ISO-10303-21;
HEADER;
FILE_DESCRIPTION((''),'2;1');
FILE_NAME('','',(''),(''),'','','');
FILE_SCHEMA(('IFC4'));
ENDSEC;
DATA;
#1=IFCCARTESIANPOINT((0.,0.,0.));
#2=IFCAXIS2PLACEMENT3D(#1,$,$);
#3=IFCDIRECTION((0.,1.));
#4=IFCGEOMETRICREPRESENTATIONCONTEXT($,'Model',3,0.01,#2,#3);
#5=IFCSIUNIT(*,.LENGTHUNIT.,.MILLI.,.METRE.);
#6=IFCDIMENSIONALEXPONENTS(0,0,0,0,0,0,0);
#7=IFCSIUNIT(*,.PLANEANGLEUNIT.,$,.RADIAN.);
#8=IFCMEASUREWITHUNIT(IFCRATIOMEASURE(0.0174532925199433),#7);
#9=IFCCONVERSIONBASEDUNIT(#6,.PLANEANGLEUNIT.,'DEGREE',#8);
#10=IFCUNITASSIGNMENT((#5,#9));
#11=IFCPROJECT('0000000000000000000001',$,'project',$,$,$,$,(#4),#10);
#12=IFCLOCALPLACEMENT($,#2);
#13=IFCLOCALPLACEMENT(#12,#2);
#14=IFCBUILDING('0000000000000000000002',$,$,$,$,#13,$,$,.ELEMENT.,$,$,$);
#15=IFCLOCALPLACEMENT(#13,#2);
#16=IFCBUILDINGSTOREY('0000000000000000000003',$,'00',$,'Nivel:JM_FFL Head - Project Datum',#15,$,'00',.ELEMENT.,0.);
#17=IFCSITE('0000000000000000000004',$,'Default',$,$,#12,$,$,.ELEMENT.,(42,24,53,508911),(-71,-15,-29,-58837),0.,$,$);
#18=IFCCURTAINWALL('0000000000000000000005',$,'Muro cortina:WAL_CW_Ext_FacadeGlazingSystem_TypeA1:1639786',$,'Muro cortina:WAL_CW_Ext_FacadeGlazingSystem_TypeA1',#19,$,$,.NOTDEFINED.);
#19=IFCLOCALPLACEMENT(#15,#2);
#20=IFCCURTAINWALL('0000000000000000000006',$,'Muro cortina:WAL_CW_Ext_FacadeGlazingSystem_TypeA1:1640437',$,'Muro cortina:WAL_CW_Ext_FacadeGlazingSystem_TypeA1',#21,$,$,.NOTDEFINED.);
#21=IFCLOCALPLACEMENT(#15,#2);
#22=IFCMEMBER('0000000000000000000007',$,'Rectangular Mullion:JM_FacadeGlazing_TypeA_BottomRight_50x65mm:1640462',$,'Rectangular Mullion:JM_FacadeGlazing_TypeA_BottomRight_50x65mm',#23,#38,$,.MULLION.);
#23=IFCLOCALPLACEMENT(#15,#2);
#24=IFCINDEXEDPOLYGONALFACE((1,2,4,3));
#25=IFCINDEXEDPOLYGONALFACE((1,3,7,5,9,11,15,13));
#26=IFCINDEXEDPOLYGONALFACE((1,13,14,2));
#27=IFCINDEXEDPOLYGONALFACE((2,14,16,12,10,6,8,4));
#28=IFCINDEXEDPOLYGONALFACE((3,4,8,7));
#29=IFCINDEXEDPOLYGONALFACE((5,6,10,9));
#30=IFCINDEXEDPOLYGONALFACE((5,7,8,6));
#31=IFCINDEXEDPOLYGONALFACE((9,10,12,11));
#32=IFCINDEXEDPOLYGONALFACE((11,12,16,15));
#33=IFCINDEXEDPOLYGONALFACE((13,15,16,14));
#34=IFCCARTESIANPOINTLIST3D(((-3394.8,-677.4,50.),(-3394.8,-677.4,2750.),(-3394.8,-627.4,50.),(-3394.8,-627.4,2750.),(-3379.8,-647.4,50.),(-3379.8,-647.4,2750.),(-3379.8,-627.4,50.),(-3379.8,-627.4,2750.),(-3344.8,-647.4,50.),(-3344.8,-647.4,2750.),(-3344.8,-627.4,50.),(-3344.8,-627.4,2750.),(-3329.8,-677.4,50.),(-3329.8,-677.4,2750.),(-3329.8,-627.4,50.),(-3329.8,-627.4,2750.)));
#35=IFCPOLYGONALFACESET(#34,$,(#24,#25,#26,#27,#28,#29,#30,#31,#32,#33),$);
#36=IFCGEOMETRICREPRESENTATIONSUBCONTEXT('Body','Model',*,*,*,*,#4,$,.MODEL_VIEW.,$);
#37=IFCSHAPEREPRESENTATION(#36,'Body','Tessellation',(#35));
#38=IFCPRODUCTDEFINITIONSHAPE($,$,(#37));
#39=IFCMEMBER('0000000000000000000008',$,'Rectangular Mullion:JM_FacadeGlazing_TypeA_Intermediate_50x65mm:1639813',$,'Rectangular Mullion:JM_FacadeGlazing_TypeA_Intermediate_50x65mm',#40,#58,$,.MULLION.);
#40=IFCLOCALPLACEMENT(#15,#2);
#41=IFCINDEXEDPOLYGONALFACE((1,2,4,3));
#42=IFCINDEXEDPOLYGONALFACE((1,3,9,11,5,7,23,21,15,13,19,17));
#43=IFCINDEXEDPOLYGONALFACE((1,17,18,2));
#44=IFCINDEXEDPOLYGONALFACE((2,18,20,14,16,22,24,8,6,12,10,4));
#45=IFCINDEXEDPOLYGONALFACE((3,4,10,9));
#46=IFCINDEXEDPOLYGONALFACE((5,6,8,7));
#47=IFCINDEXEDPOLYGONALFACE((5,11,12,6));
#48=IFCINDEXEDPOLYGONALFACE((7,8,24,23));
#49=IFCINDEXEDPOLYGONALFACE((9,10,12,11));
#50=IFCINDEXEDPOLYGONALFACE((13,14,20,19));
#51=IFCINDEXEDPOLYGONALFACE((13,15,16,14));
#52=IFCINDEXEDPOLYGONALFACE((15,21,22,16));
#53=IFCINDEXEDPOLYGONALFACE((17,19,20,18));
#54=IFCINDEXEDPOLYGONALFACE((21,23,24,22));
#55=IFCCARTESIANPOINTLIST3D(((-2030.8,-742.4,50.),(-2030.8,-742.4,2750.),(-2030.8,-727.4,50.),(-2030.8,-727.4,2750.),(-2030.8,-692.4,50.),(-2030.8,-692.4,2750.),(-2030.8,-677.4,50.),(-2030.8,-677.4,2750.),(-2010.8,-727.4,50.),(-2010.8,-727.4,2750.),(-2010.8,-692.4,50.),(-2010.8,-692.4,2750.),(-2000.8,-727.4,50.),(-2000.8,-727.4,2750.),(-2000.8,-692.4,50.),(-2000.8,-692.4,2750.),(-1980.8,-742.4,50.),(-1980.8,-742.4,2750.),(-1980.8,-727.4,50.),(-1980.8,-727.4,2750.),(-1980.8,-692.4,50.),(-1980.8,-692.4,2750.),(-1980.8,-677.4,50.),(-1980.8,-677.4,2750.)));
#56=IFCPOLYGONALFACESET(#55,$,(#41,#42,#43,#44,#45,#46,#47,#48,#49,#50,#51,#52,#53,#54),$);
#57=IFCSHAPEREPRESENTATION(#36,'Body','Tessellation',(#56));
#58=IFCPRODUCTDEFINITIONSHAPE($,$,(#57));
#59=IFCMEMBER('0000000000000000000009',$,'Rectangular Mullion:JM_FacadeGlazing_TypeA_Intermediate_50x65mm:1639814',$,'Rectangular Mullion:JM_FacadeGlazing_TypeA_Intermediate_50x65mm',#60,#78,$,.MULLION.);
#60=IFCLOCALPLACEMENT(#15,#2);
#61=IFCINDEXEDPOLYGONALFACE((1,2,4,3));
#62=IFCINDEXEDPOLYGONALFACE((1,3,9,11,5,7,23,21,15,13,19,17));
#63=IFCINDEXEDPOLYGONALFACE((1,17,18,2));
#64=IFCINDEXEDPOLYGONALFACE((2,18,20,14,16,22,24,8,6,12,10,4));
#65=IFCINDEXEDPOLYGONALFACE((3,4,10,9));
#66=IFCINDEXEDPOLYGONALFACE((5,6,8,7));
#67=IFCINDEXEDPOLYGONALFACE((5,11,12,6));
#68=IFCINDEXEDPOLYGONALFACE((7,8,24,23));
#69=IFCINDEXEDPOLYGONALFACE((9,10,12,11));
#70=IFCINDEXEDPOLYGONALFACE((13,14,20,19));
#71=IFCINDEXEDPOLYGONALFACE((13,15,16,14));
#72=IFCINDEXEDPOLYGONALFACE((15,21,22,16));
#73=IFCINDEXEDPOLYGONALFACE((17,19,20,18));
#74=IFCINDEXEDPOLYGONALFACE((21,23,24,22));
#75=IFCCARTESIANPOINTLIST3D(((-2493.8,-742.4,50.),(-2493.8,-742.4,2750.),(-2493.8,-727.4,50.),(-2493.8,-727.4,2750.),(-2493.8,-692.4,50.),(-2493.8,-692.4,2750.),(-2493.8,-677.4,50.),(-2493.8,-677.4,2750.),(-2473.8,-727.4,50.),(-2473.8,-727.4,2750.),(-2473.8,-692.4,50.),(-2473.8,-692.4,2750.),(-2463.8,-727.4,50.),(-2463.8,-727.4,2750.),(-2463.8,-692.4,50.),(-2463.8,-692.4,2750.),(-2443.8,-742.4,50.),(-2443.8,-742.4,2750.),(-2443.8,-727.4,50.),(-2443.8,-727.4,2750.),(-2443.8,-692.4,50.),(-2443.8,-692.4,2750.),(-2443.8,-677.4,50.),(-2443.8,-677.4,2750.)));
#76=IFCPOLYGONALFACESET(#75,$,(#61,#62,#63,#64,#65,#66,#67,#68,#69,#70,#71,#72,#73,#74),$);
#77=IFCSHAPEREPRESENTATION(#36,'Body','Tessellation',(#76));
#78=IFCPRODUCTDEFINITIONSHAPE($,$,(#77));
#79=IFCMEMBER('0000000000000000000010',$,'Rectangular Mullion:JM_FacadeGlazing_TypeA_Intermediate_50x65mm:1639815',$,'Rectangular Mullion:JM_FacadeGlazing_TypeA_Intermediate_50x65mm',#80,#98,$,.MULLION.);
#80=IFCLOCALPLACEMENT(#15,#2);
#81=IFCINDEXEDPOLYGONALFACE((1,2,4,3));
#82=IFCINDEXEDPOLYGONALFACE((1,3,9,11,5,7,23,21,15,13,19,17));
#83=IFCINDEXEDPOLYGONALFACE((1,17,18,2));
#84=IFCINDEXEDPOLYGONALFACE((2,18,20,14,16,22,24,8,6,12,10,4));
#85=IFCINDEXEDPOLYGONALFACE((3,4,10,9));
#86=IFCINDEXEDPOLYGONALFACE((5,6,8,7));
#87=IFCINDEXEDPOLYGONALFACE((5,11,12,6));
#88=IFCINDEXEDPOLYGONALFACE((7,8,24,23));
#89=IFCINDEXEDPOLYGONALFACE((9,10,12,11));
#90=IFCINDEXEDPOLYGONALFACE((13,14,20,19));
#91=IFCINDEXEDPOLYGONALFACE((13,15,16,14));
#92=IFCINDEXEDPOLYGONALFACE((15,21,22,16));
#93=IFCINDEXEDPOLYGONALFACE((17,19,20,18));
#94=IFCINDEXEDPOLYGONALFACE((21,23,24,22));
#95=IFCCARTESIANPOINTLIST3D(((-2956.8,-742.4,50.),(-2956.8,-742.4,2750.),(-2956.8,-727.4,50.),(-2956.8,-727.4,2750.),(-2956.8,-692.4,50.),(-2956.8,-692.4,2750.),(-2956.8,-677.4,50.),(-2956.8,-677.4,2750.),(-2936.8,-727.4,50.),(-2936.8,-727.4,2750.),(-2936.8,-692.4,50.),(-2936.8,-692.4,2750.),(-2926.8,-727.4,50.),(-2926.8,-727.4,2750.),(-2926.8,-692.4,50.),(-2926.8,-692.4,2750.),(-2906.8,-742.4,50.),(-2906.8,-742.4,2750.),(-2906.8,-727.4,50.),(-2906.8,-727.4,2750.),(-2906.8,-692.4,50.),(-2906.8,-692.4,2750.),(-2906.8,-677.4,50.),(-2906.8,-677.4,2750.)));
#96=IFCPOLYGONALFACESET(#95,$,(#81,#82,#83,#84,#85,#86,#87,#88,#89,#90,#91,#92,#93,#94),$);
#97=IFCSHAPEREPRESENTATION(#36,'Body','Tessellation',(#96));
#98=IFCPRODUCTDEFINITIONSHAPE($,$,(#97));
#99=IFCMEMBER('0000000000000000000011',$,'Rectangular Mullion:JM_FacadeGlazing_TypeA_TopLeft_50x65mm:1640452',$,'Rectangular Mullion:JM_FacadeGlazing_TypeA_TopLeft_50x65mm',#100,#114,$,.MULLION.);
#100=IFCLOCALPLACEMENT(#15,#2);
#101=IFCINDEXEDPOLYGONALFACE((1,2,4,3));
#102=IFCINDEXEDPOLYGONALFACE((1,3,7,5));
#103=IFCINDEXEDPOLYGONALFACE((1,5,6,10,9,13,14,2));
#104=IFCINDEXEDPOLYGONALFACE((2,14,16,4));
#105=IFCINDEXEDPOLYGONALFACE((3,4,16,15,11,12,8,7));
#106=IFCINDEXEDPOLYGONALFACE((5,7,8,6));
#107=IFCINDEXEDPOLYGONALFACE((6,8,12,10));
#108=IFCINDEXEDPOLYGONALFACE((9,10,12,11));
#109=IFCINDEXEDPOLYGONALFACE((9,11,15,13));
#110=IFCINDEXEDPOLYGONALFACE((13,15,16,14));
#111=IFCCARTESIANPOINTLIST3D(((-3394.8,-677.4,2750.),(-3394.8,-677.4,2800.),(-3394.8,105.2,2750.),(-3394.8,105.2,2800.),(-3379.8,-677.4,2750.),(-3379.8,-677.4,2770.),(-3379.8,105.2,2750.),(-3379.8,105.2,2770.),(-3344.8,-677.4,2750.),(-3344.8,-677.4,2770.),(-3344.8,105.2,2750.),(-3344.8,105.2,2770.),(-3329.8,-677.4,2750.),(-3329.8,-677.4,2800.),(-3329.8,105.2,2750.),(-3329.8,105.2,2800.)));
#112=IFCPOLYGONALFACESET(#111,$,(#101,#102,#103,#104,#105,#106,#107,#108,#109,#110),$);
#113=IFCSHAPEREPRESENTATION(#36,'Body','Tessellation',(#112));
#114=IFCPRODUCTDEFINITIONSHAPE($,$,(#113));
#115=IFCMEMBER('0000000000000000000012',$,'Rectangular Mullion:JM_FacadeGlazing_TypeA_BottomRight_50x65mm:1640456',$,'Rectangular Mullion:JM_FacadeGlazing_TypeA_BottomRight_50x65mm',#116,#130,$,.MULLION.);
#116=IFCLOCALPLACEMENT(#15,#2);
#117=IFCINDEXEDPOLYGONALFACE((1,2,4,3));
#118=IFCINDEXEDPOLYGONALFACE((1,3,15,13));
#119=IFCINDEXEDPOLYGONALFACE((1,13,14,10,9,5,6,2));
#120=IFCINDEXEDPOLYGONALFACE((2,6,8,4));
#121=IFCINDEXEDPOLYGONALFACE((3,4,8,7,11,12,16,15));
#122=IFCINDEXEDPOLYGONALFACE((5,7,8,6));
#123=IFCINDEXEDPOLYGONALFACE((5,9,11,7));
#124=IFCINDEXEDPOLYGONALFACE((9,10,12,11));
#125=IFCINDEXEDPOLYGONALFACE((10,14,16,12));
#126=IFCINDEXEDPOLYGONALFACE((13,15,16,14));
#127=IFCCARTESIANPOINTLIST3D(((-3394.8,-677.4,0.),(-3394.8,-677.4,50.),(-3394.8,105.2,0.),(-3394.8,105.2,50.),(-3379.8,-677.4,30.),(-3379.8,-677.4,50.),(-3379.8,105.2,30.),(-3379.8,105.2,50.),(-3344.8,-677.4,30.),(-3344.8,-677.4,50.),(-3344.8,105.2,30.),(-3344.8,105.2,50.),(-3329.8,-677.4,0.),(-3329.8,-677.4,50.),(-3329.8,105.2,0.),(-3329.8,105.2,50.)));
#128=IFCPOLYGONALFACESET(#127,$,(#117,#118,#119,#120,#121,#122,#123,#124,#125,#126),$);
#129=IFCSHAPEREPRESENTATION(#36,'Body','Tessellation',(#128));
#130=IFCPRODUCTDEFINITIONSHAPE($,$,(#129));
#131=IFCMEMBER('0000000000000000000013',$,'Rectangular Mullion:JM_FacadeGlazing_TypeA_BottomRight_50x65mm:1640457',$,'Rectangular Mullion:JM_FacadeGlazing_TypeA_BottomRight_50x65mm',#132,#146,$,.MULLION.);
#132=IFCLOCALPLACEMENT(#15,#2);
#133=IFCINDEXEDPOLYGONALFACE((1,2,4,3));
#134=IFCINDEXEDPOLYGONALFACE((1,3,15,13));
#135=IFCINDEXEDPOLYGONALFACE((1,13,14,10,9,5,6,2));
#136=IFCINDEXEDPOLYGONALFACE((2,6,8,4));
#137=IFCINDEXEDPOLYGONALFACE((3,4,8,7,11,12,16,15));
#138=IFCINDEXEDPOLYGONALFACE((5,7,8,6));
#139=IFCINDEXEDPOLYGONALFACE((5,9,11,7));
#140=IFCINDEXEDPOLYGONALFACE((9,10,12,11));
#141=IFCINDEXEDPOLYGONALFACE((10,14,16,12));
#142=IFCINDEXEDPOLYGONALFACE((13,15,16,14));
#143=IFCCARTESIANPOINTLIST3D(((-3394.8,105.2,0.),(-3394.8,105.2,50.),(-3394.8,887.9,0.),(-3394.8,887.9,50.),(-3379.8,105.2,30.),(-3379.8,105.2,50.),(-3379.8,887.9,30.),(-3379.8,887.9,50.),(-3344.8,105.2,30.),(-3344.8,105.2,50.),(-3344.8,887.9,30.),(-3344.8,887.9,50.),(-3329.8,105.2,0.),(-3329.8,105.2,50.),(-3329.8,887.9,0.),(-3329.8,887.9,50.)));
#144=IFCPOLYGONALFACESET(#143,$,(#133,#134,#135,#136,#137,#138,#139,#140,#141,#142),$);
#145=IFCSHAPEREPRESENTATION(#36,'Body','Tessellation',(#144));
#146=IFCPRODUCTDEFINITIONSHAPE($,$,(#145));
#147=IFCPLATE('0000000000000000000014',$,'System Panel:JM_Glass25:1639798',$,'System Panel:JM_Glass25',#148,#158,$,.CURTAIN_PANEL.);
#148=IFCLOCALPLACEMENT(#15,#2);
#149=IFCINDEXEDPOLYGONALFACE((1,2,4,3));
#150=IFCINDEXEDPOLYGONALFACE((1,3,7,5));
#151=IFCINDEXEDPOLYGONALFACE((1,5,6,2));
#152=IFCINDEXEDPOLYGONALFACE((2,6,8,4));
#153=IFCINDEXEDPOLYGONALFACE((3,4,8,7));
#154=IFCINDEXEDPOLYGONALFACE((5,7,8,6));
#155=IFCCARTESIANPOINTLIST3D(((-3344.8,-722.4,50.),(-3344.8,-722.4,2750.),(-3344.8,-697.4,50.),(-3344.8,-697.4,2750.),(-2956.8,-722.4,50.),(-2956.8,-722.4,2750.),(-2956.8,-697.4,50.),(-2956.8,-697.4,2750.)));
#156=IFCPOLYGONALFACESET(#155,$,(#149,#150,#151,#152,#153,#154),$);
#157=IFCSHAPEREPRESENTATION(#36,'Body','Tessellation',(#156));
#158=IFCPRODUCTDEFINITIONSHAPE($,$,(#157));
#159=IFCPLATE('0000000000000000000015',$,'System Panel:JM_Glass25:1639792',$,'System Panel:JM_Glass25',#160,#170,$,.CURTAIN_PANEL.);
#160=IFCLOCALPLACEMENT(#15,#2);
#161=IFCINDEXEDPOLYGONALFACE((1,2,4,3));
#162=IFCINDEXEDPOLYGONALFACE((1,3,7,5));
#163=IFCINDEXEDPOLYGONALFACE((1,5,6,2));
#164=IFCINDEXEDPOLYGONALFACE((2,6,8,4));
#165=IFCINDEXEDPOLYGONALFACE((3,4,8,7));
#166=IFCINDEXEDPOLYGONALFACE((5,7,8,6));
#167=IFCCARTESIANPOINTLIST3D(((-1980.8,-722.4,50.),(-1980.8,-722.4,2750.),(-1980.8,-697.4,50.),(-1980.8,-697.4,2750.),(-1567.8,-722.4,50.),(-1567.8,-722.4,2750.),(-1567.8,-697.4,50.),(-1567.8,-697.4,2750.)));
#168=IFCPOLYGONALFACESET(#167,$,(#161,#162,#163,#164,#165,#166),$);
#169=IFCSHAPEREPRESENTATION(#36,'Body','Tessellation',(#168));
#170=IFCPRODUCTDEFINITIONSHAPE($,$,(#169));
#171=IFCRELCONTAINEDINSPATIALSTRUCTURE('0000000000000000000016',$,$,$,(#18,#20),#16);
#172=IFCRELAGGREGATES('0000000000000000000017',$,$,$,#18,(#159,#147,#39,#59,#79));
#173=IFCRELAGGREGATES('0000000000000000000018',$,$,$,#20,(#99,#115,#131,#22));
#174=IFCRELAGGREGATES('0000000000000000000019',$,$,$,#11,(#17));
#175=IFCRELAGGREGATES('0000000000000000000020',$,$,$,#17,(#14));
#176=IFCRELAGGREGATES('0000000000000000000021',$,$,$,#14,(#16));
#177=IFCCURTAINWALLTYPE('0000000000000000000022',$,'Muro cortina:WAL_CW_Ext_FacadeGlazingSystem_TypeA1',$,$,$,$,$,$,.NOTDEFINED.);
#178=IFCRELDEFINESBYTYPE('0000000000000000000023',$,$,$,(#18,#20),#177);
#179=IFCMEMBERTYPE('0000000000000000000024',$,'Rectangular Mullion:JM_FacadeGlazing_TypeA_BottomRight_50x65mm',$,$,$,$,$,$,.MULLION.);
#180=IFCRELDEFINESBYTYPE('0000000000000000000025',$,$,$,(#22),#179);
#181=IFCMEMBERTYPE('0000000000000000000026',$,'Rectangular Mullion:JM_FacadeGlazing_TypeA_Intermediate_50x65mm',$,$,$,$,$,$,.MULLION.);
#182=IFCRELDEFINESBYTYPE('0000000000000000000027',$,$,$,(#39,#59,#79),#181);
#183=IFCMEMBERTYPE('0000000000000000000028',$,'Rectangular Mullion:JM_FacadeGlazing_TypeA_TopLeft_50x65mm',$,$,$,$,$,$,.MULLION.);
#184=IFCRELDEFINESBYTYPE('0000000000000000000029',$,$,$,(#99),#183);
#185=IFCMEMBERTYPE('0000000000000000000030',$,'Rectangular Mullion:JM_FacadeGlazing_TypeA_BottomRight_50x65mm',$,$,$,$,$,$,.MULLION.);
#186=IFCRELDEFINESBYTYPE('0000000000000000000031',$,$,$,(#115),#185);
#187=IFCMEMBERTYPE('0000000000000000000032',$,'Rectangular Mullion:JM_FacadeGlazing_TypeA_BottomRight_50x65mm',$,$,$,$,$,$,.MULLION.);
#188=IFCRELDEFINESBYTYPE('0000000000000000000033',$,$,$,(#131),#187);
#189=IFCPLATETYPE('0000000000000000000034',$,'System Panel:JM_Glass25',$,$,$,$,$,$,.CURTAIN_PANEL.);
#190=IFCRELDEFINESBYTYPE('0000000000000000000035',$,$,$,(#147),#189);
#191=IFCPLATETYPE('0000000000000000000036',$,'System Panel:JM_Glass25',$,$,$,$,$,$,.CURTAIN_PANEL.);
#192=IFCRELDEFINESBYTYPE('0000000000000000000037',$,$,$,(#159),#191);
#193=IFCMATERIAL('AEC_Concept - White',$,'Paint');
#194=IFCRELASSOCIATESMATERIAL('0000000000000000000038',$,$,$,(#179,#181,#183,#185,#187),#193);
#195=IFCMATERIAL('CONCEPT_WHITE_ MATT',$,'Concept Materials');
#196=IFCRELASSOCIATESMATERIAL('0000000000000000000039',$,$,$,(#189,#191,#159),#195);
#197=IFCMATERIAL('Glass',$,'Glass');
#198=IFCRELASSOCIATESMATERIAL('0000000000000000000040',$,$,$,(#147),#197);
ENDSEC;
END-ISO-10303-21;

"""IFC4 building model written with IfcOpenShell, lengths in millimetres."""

from ifc_helpers import new_model, entity, si_unit, converted_unit, direction, frame, origin, place, context, subcontext, project, spatial, indexed_curve, outline, extrude, source, transform, mapped, material, type_object, type_shapes, element, aggregate, save


model = new_model("IFC4")

# Units and contexts
model_context = context("Model", 3, precision=0.01, world=origin(), true_north=direction((0.0, 1.0)))
body_context = subcontext(model_context, "Body", "Model", "MODEL_VIEW")
ifc_project = project(units=[si_unit("LENGTHUNIT", "METRE", prefix="MILLI"), converted_unit("PLANEANGLEUNIT", "DEGREE", entity("IfcRatioMeasure", 0.0174532925199433), si_unit("PLANEANGLEUNIT", "RADIAN"), dimensions=[0, 0, 0, 0, 0, 0, 0])], contexts=[model_context])

# Site, building, storey
site_placement = place(None, origin())
site = spatial("IfcSite", under=ifc_project, at=site_placement, Name="Default", CompositionType="ELEMENT", RefLatitude=(42, 24, 53, 508911), RefLongitude=(-71, -15, -29, -58837), RefElevation=0.0)
building_placement = place(site_placement, origin())
building = spatial("IfcBuilding", under=site, at=building_placement, CompositionType="ELEMENT")
storey_placement = place(building_placement, origin())
storey = spatial("IfcBuildingStorey", under=building, at=storey_placement, Name="00", ObjectType="Nivel:JM_FFL Head - Project Datum", LongName="00", CompositionType="ELEMENT", Elevation=0.0)

# Curtain wall
curtain_wall_type = type_object("IfcCurtainWallType", Name="Muro cortina:WAL_CW_Ext_FacadeGlazingSystem_TypeA1", PredefinedType="NOTDEFINED")
curtain_wall_1_placement = place(storey_placement, origin())
curtain_wall_1 = element("IfcCurtainWall", 1, at=curtain_wall_1_placement, inside=storey, type_object=curtain_wall_type, Name="Muro cortina:WAL_CW_Ext_FacadeGlazingSystem_TypeA1:1639786", ObjectType="Muro cortina:WAL_CW_Ext_FacadeGlazingSystem_TypeA1", PredefinedType="NOTDEFINED")
ifc_material_1 = material(Name="AEC_Concept - White", Category="Paint")

# Curtain wall, member
curtain_wall_2_placement = place(storey_placement, origin())
curtain_wall_2 = element("IfcCurtainWall", 2, at=curtain_wall_2_placement, inside=storey, type_object=curtain_wall_type, Name="Muro cortina:WAL_CW_Ext_FacadeGlazingSystem_TypeA1:1640437", ObjectType="Muro cortina:WAL_CW_Ext_FacadeGlazingSystem_TypeA1", PredefinedType="NOTDEFINED")
member_type_1 = type_object("IfcMemberType", Name="Rectangular Mullion:JM_FacadeGlazing_TypeA_BottomRight_50x65mm", PredefinedType="MULLION", material=ifc_material_1)
shared_shape_1 = source(origin(), body_context, "Body", "SweptSolid", [
    extrude(outline(indexed_curve([(-32.5, -17.5), (-17.5, -17.5), (-17.5, 2.5), (17.5, 2.5), (17.5, -17.5), (32.5, -17.5), (32.5, 32.5), (-32.5, 32.5), (-32.5, -17.5)], self_intersect=False)), frame((-32.5, -32.5, -2700.0), z_axis=(0.0, 0.0, 1.0), x_axis=(0.0, -1.0, 0.0)), (0.0, 0.0, 1.0), 2700.0),
])
type_shapes(member_type_1, [shared_shape_1])
member_1_placement = place(curtain_wall_2_placement, frame((-3329.8, -677.4, 2750.0), z_axis=(0.0, 0.0, 1.0), x_axis=(0.0, -1.0, 0.0)))
member_1 = element("IfcMember", 3, at=member_1_placement, type_object=member_type_1, Name="Rectangular Mullion:JM_FacadeGlazing_TypeA_BottomRight_50x65mm:1640462", ObjectType="Rectangular Mullion:JM_FacadeGlazing_TypeA_BottomRight_50x65mm", PredefinedType="MULLION", context=body_context, shape_type="MappedRepresentation", body=[
    mapped(shared_shape_1, transform((0.0, 0.0, 0.0), scale=1.0)),
])

# Members
member_type_2 = type_object("IfcMemberType", Name="Rectangular Mullion:JM_FacadeGlazing_TypeA_Intermediate_50x65mm", PredefinedType="MULLION", material=ifc_material_1)
shared_shape_2 = source(origin(), body_context, "Body", "SweptSolid", [
    extrude(outline(indexed_curve([(-32.5, -25.0), (-17.5, -25.0), (-17.5, -5.0), (17.5, -5.0), (17.5, -25.0), (32.5, -25.0), (32.5, 25.0), (17.5, 25.0), (17.5, 5.0), (-17.5, 5.0), (-17.5, 25.0), (-32.5, 25.0), (-32.5, -25.0)], self_intersect=False)), frame((0.0, -32.5, -2700.0), z_axis=(0.0, 0.0, 1.0), x_axis=(0.0, -1.0, 0.0)), (0.0, 0.0, 1.0), 2700.0),
])
type_shapes(member_type_2, [shared_shape_2])
member_2_placement = place(curtain_wall_1_placement, frame((-2005.8, -677.4, 50.0), z_axis=(0.0, 0.0, -1.0), x_axis=(-1.0, 0.0, 0.0)))
member_2 = element("IfcMember", 4, at=member_2_placement, type_object=member_type_2, Name="Rectangular Mullion:JM_FacadeGlazing_TypeA_Intermediate_50x65mm:1639813", ObjectType="Rectangular Mullion:JM_FacadeGlazing_TypeA_Intermediate_50x65mm", PredefinedType="MULLION", context=body_context, shape_type="MappedRepresentation", body=[
    mapped(shared_shape_2, transform((0.0, 0.0, 0.0), scale=1.0)),
])
member_3_placement = place(curtain_wall_1_placement, frame((-2468.8, -677.4, 50.0), z_axis=(0.0, 0.0, -1.0), x_axis=(-1.0, 0.0, 0.0)))
member_3 = element("IfcMember", 5, at=member_3_placement, type_object=member_type_2, Name="Rectangular Mullion:JM_FacadeGlazing_TypeA_Intermediate_50x65mm:1639814", ObjectType="Rectangular Mullion:JM_FacadeGlazing_TypeA_Intermediate_50x65mm", PredefinedType="MULLION", context=body_context, shape_type="MappedRepresentation", body=[
    mapped(shared_shape_2, transform((0.0, 0.0, 0.0), scale=1.0)),
])
member_4_placement = place(curtain_wall_1_placement, frame((-2931.8, -677.4, 50.0), z_axis=(0.0, 0.0, -1.0), x_axis=(-1.0, 0.0, 0.0)))
member_4 = element("IfcMember", 6, at=member_4_placement, type_object=member_type_2, Name="Rectangular Mullion:JM_FacadeGlazing_TypeA_Intermediate_50x65mm:1639815", ObjectType="Rectangular Mullion:JM_FacadeGlazing_TypeA_Intermediate_50x65mm", PredefinedType="MULLION", context=body_context, shape_type="MappedRepresentation", body=[
    mapped(shared_shape_2, transform((0.0, 0.0, 0.0), scale=1.0)),
])
member_type_3 = type_object("IfcMemberType", Name="Rectangular Mullion:JM_FacadeGlazing_TypeA_TopLeft_50x65mm", PredefinedType="MULLION", material=ifc_material_1)
shared_shape_3 = source(origin(), body_context, "Body", "SweptSolid", [
    extrude(outline(indexed_curve([(-32.5, -17.5), (-17.5, -17.5), (-17.5, 2.5), (17.5, 2.5), (17.5, -17.5), (32.5, -17.5), (32.5, 32.5), (-32.5, 32.5), (-32.5, -17.5)], self_intersect=False)), frame((-32.5, -32.5, -782.6), z_axis=(0.0, 0.0, 1.0), x_axis=(0.0, -1.0, 0.0)), (0.0, 0.0, 1.0), 782.6),
])
type_shapes(member_type_3, [shared_shape_3])
member_5_placement = place(curtain_wall_2_placement, frame((-3329.8, 105.2, 2800.0), z_axis=(0.0, 1.0, 0.0), x_axis=(0.0, 0.0, 1.0)))
member_5 = element("IfcMember", 7, at=member_5_placement, type_object=member_type_3, Name="Rectangular Mullion:JM_FacadeGlazing_TypeA_TopLeft_50x65mm:1640452", ObjectType="Rectangular Mullion:JM_FacadeGlazing_TypeA_TopLeft_50x65mm", PredefinedType="MULLION", context=body_context, shape_type="MappedRepresentation", body=[
    mapped(shared_shape_3, transform((0.0, 0.0, 0.0), scale=1.0)),
])
member_type_4 = type_object("IfcMemberType", Name="Rectangular Mullion:JM_FacadeGlazing_TypeA_BottomRight_50x65mm", PredefinedType="MULLION", material=ifc_material_1)
shared_shape_4 = source(origin(), body_context, "Body", "SweptSolid", [
    extrude(outline(indexed_curve([(-32.5, -17.5), (-17.5, -17.5), (-17.5, 2.5), (17.5, 2.5), (17.5, -17.5), (32.5, -17.5), (32.5, 32.5), (-32.5, 32.5), (-32.5, -17.5)], self_intersect=False)), frame((-32.5, -32.5, -782.6), z_axis=(0.0, 0.0, 1.0), x_axis=(0.0, -1.0, 0.0)), (0.0, 0.0, 1.0), 782.6),
])
type_shapes(member_type_4, [shared_shape_4])
member_6_placement = place(curtain_wall_2_placement, frame((-3329.8, -677.4, 0.0), z_axis=(0.0, -1.0, 0.0), x_axis=(0.0, 0.0, -1.0)))
member_6 = element("IfcMember", 8, at=member_6_placement, type_object=member_type_4, Name="Rectangular Mullion:JM_FacadeGlazing_TypeA_BottomRight_50x65mm:1640456", ObjectType="Rectangular Mullion:JM_FacadeGlazing_TypeA_BottomRight_50x65mm", PredefinedType="MULLION", context=body_context, shape_type="MappedRepresentation", body=[
    mapped(shared_shape_4, transform((0.0, 0.0, 0.0), scale=1.0)),
])
member_type_5 = type_object("IfcMemberType", Name="Rectangular Mullion:JM_FacadeGlazing_TypeA_BottomRight_50x65mm", PredefinedType="MULLION", material=ifc_material_1)
shared_shape_5 = source(origin(), body_context, "Body", "SweptSolid", [
    extrude(outline(indexed_curve([(-32.5, -17.5), (-17.5, -17.5), (-17.5, 2.5), (17.5, 2.5), (17.5, -17.5), (32.5, -17.5), (32.5, 32.5), (-32.5, 32.5), (-32.5, -17.5)], self_intersect=False)), frame((-32.5, -32.5, -782.6), z_axis=(0.0, 0.0, 1.0), x_axis=(0.0, -1.0, 0.0)), (0.0, 0.0, 1.0), 782.6),
])
type_shapes(member_type_5, [shared_shape_5])
member_7_placement = place(curtain_wall_2_placement, frame((-3329.8, 105.2, 0.0), z_axis=(0.0, -1.0, 0.0), x_axis=(0.0, 0.0, -1.0)))
member_7 = element("IfcMember", 9, at=member_7_placement, type_object=member_type_5, Name="Rectangular Mullion:JM_FacadeGlazing_TypeA_BottomRight_50x65mm:1640457", ObjectType="Rectangular Mullion:JM_FacadeGlazing_TypeA_BottomRight_50x65mm", PredefinedType="MULLION", context=body_context, shape_type="MappedRepresentation", body=[
    mapped(shared_shape_5, transform((0.0, 0.0, 0.0), scale=1.0)),
])

# Plates
ifc_material_2 = material(Name="Glass", Category="Glass")
ifc_material_3 = material(Name="CONCEPT_WHITE_ MATT", Category="Concept Materials")
plate_type_1 = type_object("IfcPlateType", Name="System Panel:JM_Glass25", PredefinedType="CURTAIN_PANEL", material=ifc_material_3)
shared_shape_6 = source(origin(), body_context, "Body", "SweptSolid", [
    extrude(outline(indexed_curve([(-12.5, -194.0), (12.5, -194.0), (12.5, 194.0), (-12.5, 194.0), (-12.5, -194.0)], self_intersect=False)), frame((0.0, 32.5, 0.0), z_axis=(0.0, 0.0, 1.0), x_axis=(0.0, 1.0, 0.0)), (0.0, 0.0, 1.0), 2700.0),
])
type_shapes(plate_type_1, [shared_shape_6])
plate_1_placement = place(curtain_wall_1_placement, frame((-3150.8, -677.4, 50.0), z_axis=(0.0, 0.0, 1.0), x_axis=(-1.0, 0.0, 0.0)))
plate_1 = element("IfcPlate", 10, at=plate_1_placement, type_object=plate_type_1, material=ifc_material_2, Name="System Panel:JM_Glass25:1639798", ObjectType="System Panel:JM_Glass25", PredefinedType="CURTAIN_PANEL", context=body_context, shape_type="MappedRepresentation", body=[
    mapped(shared_shape_6, transform((0.0, 0.0, 0.0), scale=1.0)),
])
plate_type_2 = type_object("IfcPlateType", Name="System Panel:JM_Glass25", PredefinedType="CURTAIN_PANEL", material=ifc_material_3)
shared_shape_7 = source(origin(), body_context, "Body", "SweptSolid", [
    extrude(outline(indexed_curve([(-12.5, -206.5), (12.5, -206.5), (12.5, 206.5), (-12.5, 206.5), (-12.5, -206.5)], self_intersect=False)), frame((0.0, 32.5, 0.0), z_axis=(0.0, 0.0, 1.0), x_axis=(0.0, 1.0, 0.0)), (0.0, 0.0, 1.0), 2700.0),
])
type_shapes(plate_type_2, [shared_shape_7])
plate_2_placement = place(curtain_wall_1_placement, frame((-1774.3, -677.4, 50.0), z_axis=(0.0, 0.0, 1.0), x_axis=(-1.0, 0.0, 0.0)))
plate_2 = element("IfcPlate", 11, at=plate_2_placement, type_object=plate_type_2, material=ifc_material_3, Name="System Panel:JM_Glass25:1639792", ObjectType="System Panel:JM_Glass25", PredefinedType="CURTAIN_PANEL", context=body_context, shape_type="MappedRepresentation", body=[
    mapped(shared_shape_7, transform((0.0, 0.0, 0.0), scale=1.0)),
])
aggregate(curtain_wall_1, [plate_2, plate_1, member_2, member_3, member_4])
aggregate(curtain_wall_2, [member_5, member_6, member_7, member_1])

save(model, "model.ifc")
